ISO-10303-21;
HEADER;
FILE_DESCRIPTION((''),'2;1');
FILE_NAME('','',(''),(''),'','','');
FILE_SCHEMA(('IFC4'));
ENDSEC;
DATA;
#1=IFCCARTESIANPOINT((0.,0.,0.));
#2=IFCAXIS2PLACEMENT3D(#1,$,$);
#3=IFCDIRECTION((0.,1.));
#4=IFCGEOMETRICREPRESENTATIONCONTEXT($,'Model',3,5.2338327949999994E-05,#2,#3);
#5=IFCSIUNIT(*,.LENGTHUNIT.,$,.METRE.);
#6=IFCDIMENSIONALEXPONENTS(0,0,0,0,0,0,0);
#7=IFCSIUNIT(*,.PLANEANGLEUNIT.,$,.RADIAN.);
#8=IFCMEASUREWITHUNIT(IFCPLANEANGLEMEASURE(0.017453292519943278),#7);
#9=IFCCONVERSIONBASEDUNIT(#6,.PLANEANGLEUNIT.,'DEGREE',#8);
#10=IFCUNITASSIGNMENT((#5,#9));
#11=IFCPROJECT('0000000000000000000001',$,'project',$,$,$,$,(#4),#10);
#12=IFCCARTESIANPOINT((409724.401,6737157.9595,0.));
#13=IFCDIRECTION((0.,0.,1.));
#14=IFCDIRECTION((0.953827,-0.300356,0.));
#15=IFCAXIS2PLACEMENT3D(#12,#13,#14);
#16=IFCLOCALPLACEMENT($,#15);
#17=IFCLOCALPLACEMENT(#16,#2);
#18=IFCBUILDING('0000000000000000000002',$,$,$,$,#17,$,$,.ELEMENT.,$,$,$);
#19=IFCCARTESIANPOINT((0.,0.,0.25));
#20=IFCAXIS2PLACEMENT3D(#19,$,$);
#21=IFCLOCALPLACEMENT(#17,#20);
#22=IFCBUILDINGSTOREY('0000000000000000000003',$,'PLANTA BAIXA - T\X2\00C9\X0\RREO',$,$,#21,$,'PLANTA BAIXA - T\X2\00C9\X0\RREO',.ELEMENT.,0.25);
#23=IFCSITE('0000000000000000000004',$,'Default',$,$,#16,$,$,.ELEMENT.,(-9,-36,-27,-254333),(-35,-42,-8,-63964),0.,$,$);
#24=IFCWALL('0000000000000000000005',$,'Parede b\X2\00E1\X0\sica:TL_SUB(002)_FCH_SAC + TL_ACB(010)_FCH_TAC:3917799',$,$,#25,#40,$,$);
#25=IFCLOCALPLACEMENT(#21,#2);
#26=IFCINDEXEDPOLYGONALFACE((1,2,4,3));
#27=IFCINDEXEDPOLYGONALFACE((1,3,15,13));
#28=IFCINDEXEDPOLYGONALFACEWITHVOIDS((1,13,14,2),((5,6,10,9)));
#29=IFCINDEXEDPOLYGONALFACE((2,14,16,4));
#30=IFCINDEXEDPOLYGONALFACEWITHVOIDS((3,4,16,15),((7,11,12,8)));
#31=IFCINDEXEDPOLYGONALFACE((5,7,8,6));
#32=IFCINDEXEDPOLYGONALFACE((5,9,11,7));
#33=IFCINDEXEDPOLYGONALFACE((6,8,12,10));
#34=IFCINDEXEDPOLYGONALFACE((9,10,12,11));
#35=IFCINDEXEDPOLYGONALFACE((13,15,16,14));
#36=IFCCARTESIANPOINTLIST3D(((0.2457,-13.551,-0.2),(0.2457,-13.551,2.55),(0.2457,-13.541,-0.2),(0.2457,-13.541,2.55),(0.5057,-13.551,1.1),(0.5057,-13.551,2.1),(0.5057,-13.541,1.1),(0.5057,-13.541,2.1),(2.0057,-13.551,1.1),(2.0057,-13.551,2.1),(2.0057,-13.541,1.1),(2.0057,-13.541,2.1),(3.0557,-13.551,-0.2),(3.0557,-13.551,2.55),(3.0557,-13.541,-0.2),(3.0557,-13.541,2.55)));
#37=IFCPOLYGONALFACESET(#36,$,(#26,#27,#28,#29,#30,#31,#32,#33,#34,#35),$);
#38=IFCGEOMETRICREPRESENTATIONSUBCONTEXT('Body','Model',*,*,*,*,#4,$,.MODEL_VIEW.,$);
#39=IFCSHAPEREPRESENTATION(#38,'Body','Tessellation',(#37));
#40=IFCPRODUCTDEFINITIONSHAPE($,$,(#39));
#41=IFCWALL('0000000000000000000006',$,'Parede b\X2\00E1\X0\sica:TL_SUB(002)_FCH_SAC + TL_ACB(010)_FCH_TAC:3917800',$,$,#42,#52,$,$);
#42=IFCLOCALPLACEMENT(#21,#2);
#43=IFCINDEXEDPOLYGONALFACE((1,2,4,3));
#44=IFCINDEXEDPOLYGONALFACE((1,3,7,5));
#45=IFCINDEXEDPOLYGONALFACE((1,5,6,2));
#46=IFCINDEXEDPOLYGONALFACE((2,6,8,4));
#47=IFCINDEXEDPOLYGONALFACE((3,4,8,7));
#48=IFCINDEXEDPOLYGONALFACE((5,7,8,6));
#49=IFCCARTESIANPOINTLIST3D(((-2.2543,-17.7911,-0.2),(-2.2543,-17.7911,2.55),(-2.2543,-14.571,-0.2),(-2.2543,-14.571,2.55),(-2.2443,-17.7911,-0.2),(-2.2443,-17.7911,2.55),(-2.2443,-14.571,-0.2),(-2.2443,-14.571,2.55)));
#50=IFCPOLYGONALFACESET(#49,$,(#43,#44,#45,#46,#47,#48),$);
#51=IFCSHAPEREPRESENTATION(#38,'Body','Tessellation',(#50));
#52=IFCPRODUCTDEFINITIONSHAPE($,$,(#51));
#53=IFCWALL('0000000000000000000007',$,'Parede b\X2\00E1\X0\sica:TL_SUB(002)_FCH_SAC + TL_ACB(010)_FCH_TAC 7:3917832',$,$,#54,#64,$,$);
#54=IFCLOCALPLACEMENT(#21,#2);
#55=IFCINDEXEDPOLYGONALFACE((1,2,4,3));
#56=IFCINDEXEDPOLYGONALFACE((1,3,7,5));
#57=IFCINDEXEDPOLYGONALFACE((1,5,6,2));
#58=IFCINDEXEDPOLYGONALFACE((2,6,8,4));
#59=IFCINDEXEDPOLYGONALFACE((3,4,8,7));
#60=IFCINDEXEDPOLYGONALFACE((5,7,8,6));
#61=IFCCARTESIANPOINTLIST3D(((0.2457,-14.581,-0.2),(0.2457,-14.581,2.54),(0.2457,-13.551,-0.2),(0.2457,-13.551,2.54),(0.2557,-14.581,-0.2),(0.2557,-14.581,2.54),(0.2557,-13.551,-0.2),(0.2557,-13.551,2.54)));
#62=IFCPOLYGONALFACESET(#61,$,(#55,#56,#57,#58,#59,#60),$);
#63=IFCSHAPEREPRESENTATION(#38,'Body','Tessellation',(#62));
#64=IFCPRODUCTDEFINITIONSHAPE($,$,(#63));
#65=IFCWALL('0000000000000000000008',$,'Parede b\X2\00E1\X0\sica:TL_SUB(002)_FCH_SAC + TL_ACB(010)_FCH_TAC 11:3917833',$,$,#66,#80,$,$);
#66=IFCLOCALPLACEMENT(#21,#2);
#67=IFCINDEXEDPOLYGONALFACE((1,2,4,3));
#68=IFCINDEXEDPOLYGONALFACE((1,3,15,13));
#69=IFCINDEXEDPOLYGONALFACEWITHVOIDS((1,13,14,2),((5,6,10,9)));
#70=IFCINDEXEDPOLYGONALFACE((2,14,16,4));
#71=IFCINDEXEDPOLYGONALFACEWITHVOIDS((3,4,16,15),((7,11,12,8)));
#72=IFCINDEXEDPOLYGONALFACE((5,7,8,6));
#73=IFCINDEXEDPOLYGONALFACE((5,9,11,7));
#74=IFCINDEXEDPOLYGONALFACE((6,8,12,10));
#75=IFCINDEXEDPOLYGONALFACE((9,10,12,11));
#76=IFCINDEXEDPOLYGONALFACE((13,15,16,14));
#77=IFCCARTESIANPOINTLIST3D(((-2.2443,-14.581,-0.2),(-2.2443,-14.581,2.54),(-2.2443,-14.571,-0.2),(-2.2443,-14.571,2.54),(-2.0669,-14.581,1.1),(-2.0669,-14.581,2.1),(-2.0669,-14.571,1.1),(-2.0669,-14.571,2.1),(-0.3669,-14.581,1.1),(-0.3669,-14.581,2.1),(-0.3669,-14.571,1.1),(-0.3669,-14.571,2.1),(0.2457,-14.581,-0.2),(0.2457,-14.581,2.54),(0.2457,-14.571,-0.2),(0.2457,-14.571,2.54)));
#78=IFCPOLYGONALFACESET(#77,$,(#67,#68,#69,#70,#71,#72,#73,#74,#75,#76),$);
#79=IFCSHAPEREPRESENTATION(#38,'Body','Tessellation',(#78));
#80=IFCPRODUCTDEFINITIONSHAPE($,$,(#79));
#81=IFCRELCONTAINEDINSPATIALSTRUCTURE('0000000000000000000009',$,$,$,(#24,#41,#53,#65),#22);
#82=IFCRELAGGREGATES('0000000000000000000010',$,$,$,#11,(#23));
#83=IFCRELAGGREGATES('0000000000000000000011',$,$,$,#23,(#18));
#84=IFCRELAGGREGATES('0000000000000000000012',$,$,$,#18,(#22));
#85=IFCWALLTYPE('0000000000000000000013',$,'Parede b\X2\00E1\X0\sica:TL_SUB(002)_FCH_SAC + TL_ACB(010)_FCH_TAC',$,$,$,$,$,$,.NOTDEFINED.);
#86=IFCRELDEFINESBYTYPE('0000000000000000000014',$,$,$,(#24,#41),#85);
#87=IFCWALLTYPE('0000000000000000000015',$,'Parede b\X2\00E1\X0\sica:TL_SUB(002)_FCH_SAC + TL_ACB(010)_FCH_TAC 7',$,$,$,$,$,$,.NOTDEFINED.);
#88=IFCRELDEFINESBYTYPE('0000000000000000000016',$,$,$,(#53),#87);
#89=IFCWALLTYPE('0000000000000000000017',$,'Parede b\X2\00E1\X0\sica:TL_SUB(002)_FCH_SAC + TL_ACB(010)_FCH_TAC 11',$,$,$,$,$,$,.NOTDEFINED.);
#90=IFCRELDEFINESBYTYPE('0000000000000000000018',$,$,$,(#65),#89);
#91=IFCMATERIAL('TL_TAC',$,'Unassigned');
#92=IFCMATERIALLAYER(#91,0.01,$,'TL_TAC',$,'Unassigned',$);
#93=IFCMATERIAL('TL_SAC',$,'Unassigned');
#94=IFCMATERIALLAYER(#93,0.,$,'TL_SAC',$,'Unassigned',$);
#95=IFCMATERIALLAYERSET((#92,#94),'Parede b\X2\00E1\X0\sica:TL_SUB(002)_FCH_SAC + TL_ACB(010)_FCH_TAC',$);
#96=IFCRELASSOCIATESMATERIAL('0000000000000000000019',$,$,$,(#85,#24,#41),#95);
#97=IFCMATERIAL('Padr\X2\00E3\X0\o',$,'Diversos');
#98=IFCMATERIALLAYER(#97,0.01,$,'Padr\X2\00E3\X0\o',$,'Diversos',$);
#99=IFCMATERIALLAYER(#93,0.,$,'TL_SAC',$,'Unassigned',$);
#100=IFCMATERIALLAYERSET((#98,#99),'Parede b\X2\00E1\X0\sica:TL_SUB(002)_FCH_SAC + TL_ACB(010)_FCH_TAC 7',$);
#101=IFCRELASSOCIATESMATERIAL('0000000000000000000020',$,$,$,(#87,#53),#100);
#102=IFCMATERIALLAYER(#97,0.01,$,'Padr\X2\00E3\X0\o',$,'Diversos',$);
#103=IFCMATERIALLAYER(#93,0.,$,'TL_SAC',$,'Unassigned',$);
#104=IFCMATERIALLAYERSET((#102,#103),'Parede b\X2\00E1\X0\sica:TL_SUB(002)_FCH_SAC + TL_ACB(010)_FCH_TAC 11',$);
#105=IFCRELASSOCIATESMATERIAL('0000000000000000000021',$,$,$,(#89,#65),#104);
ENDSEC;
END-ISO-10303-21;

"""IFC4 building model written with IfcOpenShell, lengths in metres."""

from ifc_helpers import new_model, entity, si_unit, converted_unit, direction, frame, frame_2d, origin, place, context, subcontext, project, spatial, rectangle, extrude, material, layer, layer_set, layer_usage, type_object, element, save


model = new_model("IFC4")

# Units and contexts
model_context = context("Model", 3, precision=5.2338327949999994e-05, world=origin(), true_north=direction((0.0, 1.0)))
body_context = subcontext(model_context, "Body", "Model", "MODEL_VIEW")
ifc_project = project(units=[si_unit("LENGTHUNIT", "METRE"), converted_unit("PLANEANGLEUNIT", "DEGREE", entity("IfcPlaneAngleMeasure", 0.017453292519943278), si_unit("PLANEANGLEUNIT", "RADIAN"), dimensions=[0, 0, 0, 0, 0, 0, 0])], contexts=[model_context])

# Site, building, storey
site_placement = place(None, frame((409724.401, 6737157.9595, 0.0), z_axis=(0.0, 0.0, 1.0), x_axis=(0.953827, -0.300356, 0.0)))
site = spatial("IfcSite", under=ifc_project, at=site_placement, Name="Default", CompositionType="ELEMENT", RefLatitude=(-9, -36, -27, -254333), RefLongitude=(-35, -42, -8, -63964), RefElevation=0.0)
building_placement = place(site_placement, origin())
building = spatial("IfcBuilding", under=site, at=building_placement, CompositionType="ELEMENT")
storey_placement = place(building_placement, frame((0.0, 0.0, 0.25)))
storey = spatial("IfcBuildingStorey", under=building, at=storey_placement, Name="PLANTA BAIXA - TÉRREO", LongName="PLANTA BAIXA - TÉRREO", CompositionType="ELEMENT", Elevation=0.25)

# Shared definitions
ifc_material_1 = material(Name="TL_SAC", Category="Unassigned")

# Wall, opening
ifc_material_2 = material(Name="TL_TAC", Category="Unassigned")
ifc_layer_1 = layer(ifc_material_2, 0.01, Name="TL_TAC", Category="Unassigned")
ifc_layer_2 = layer(ifc_material_1, 0.0, Name="TL_SAC", Category="Unassigned")
ifc_layer_set_1 = layer_set([ifc_layer_1, ifc_layer_2], Name="Parede básica:TL_SUB(002)_FCH_SAC + TL_ACB(010)_FCH_TAC")
ifc_layer_usage_1 = layer_usage(ifc_layer_set_1, "AXIS2", "POSITIVE", -0.005)
wall_type_1 = type_object("IfcWallType", Name="Parede básica:TL_SUB(002)_FCH_SAC + TL_ACB(010)_FCH_TAC", PredefinedType="NOTDEFINED", material=ifc_layer_set_1)
wall_1_placement = place(storey_placement, frame((3.0557, -13.546, -0.2), z_axis=(0.0, 0.0, 1.0), x_axis=(-1.0, 0.0, 0.0)))
wall_1 = element("IfcWall", 1, at=wall_1_placement, inside=storey, type_object=wall_type_1, material=ifc_layer_usage_1, Name="Parede básica:TL_SUB(002)_FCH_SAC + TL_ACB(010)_FCH_TAC:3917799", context=body_context, shape_type="SweptSolid", body=[
    extrude(rectangle(XDim=2.81, YDim=0.01, at=frame_2d((1.405, 0.0), x_axis=(-1.0, 0.0))), origin(), (0.0, 0.0, 1.0), 2.75),
])
opening_1_placement = place(wall_1_placement, frame((3.0557, -13.546, 1.3)))
element("IfcOpeningElement", 2, at=opening_1_placement, cuts=wall_1, PredefinedType="OPENING", context=body_context, shape_type="SweptSolid", body=[
    extrude(rectangle(XDim=1.0, YDim=1.5, at=frame_2d((0.0, 0.0), x_axis=(0.0, 1.0))), frame((-1.2557, 12.127, 0.5), z_axis=(0.0, 1.0, 0.0), x_axis=(1.0, 0.0, 0.0)), (0.0, 0.0, 1.0), 3.048),
])

# Walls
ifc_layer_usage_2 = layer_usage(ifc_layer_set_1, "AXIS2", "NEGATIVE", 0.005)
wall_2_placement = place(storey_placement, frame((-2.2493, -14.571, -0.2), z_axis=(0.0, 0.0, 1.0), x_axis=(0.0, -1.0, 0.0)))
element("IfcWall", 3, at=wall_2_placement, inside=storey, type_object=wall_type_1, material=ifc_layer_usage_2, Name="Parede básica:TL_SUB(002)_FCH_SAC + TL_ACB(010)_FCH_TAC:3917800", context=body_context, shape_type="SweptSolid", body=[
    extrude(rectangle(XDim=3.2201, YDim=0.01, at=frame_2d((1.6101, 0.0), x_axis=(-1.0, 0.0))), origin(), (0.0, 0.0, 1.0), 2.75),
])
ifc_material_3 = material(Name="Padrão", Category="Diversos")
ifc_layer_3 = layer(ifc_material_3, 0.01, Name="Padrão", Category="Diversos")
ifc_layer_4 = layer(ifc_material_1, 0.0, Name="TL_SAC", Category="Unassigned")
ifc_layer_set_2 = layer_set([ifc_layer_3, ifc_layer_4], Name="Parede básica:TL_SUB(002)_FCH_SAC + TL_ACB(010)_FCH_TAC 7")
ifc_layer_usage_3 = layer_usage(ifc_layer_set_2, "AXIS2", "NEGATIVE", 0.005)
wall_type_2 = type_object("IfcWallType", Name="Parede básica:TL_SUB(002)_FCH_SAC + TL_ACB(010)_FCH_TAC 7", PredefinedType="NOTDEFINED", material=ifc_layer_set_2)
wall_3_placement = place(storey_placement, frame((0.2507, -13.551, -0.2), z_axis=(0.0, 0.0, 1.0), x_axis=(0.0, -1.0, 0.0)))
element("IfcWall", 4, at=wall_3_placement, inside=storey, type_object=wall_type_2, material=ifc_layer_usage_3, Name="Parede básica:TL_SUB(002)_FCH_SAC + TL_ACB(010)_FCH_TAC 7:3917832", context=body_context, shape_type="SweptSolid", body=[
    extrude(rectangle(XDim=1.03, YDim=0.01, at=frame_2d((0.515, 0.0), x_axis=(-1.0, 0.0))), origin(), (0.0, 0.0, 1.0), 2.74),
])

# Wall, opening
ifc_layer_5 = layer(ifc_material_3, 0.01, Name="Padrão", Category="Diversos")
ifc_layer_6 = layer(ifc_material_1, 0.0, Name="TL_SAC", Category="Unassigned")
ifc_layer_set_3 = layer_set([ifc_layer_5, ifc_layer_6], Name="Parede básica:TL_SUB(002)_FCH_SAC + TL_ACB(010)_FCH_TAC 11")
ifc_layer_usage_4 = layer_usage(ifc_layer_set_3, "AXIS2", "NEGATIVE", 0.005)
wall_type_3 = type_object("IfcWallType", Name="Parede básica:TL_SUB(002)_FCH_SAC + TL_ACB(010)_FCH_TAC 11", PredefinedType="NOTDEFINED", material=ifc_layer_set_3)
wall_4_placement = place(storey_placement, frame((0.2457, -14.576, -0.2), z_axis=(0.0, 0.0, 1.0), x_axis=(-1.0, 0.0, 0.0)))
wall_4 = element("IfcWall", 5, at=wall_4_placement, inside=storey, type_object=wall_type_3, material=ifc_layer_usage_4, Name="Parede básica:TL_SUB(002)_FCH_SAC + TL_ACB(010)_FCH_TAC 11:3917833", context=body_context, shape_type="SweptSolid", body=[
    extrude(rectangle(XDim=2.49, YDim=0.01, at=frame_2d((1.245, 0.0), x_axis=(-1.0, 0.0))), origin(), (0.0, 0.0, 1.0), 2.74),
])
opening_2_placement = place(wall_4_placement, frame((0.2457, -14.576, 1.3)))
element("IfcOpeningElement", 6, at=opening_2_placement, cuts=wall_4, PredefinedType="OPENING", context=body_context, shape_type="SweptSolid", body=[
    extrude(rectangle(XDim=1.0, YDim=1.7, at=frame_2d((0.0, 0.0), x_axis=(0.0, 1.0))), frame((1.2169, 13.157, 0.5), z_axis=(0.0, 1.0, 0.0), x_axis=(1.0, 0.0, 0.0)), (0.0, 0.0, 1.0), 3.048),
])

save(model, "model.ifc")
